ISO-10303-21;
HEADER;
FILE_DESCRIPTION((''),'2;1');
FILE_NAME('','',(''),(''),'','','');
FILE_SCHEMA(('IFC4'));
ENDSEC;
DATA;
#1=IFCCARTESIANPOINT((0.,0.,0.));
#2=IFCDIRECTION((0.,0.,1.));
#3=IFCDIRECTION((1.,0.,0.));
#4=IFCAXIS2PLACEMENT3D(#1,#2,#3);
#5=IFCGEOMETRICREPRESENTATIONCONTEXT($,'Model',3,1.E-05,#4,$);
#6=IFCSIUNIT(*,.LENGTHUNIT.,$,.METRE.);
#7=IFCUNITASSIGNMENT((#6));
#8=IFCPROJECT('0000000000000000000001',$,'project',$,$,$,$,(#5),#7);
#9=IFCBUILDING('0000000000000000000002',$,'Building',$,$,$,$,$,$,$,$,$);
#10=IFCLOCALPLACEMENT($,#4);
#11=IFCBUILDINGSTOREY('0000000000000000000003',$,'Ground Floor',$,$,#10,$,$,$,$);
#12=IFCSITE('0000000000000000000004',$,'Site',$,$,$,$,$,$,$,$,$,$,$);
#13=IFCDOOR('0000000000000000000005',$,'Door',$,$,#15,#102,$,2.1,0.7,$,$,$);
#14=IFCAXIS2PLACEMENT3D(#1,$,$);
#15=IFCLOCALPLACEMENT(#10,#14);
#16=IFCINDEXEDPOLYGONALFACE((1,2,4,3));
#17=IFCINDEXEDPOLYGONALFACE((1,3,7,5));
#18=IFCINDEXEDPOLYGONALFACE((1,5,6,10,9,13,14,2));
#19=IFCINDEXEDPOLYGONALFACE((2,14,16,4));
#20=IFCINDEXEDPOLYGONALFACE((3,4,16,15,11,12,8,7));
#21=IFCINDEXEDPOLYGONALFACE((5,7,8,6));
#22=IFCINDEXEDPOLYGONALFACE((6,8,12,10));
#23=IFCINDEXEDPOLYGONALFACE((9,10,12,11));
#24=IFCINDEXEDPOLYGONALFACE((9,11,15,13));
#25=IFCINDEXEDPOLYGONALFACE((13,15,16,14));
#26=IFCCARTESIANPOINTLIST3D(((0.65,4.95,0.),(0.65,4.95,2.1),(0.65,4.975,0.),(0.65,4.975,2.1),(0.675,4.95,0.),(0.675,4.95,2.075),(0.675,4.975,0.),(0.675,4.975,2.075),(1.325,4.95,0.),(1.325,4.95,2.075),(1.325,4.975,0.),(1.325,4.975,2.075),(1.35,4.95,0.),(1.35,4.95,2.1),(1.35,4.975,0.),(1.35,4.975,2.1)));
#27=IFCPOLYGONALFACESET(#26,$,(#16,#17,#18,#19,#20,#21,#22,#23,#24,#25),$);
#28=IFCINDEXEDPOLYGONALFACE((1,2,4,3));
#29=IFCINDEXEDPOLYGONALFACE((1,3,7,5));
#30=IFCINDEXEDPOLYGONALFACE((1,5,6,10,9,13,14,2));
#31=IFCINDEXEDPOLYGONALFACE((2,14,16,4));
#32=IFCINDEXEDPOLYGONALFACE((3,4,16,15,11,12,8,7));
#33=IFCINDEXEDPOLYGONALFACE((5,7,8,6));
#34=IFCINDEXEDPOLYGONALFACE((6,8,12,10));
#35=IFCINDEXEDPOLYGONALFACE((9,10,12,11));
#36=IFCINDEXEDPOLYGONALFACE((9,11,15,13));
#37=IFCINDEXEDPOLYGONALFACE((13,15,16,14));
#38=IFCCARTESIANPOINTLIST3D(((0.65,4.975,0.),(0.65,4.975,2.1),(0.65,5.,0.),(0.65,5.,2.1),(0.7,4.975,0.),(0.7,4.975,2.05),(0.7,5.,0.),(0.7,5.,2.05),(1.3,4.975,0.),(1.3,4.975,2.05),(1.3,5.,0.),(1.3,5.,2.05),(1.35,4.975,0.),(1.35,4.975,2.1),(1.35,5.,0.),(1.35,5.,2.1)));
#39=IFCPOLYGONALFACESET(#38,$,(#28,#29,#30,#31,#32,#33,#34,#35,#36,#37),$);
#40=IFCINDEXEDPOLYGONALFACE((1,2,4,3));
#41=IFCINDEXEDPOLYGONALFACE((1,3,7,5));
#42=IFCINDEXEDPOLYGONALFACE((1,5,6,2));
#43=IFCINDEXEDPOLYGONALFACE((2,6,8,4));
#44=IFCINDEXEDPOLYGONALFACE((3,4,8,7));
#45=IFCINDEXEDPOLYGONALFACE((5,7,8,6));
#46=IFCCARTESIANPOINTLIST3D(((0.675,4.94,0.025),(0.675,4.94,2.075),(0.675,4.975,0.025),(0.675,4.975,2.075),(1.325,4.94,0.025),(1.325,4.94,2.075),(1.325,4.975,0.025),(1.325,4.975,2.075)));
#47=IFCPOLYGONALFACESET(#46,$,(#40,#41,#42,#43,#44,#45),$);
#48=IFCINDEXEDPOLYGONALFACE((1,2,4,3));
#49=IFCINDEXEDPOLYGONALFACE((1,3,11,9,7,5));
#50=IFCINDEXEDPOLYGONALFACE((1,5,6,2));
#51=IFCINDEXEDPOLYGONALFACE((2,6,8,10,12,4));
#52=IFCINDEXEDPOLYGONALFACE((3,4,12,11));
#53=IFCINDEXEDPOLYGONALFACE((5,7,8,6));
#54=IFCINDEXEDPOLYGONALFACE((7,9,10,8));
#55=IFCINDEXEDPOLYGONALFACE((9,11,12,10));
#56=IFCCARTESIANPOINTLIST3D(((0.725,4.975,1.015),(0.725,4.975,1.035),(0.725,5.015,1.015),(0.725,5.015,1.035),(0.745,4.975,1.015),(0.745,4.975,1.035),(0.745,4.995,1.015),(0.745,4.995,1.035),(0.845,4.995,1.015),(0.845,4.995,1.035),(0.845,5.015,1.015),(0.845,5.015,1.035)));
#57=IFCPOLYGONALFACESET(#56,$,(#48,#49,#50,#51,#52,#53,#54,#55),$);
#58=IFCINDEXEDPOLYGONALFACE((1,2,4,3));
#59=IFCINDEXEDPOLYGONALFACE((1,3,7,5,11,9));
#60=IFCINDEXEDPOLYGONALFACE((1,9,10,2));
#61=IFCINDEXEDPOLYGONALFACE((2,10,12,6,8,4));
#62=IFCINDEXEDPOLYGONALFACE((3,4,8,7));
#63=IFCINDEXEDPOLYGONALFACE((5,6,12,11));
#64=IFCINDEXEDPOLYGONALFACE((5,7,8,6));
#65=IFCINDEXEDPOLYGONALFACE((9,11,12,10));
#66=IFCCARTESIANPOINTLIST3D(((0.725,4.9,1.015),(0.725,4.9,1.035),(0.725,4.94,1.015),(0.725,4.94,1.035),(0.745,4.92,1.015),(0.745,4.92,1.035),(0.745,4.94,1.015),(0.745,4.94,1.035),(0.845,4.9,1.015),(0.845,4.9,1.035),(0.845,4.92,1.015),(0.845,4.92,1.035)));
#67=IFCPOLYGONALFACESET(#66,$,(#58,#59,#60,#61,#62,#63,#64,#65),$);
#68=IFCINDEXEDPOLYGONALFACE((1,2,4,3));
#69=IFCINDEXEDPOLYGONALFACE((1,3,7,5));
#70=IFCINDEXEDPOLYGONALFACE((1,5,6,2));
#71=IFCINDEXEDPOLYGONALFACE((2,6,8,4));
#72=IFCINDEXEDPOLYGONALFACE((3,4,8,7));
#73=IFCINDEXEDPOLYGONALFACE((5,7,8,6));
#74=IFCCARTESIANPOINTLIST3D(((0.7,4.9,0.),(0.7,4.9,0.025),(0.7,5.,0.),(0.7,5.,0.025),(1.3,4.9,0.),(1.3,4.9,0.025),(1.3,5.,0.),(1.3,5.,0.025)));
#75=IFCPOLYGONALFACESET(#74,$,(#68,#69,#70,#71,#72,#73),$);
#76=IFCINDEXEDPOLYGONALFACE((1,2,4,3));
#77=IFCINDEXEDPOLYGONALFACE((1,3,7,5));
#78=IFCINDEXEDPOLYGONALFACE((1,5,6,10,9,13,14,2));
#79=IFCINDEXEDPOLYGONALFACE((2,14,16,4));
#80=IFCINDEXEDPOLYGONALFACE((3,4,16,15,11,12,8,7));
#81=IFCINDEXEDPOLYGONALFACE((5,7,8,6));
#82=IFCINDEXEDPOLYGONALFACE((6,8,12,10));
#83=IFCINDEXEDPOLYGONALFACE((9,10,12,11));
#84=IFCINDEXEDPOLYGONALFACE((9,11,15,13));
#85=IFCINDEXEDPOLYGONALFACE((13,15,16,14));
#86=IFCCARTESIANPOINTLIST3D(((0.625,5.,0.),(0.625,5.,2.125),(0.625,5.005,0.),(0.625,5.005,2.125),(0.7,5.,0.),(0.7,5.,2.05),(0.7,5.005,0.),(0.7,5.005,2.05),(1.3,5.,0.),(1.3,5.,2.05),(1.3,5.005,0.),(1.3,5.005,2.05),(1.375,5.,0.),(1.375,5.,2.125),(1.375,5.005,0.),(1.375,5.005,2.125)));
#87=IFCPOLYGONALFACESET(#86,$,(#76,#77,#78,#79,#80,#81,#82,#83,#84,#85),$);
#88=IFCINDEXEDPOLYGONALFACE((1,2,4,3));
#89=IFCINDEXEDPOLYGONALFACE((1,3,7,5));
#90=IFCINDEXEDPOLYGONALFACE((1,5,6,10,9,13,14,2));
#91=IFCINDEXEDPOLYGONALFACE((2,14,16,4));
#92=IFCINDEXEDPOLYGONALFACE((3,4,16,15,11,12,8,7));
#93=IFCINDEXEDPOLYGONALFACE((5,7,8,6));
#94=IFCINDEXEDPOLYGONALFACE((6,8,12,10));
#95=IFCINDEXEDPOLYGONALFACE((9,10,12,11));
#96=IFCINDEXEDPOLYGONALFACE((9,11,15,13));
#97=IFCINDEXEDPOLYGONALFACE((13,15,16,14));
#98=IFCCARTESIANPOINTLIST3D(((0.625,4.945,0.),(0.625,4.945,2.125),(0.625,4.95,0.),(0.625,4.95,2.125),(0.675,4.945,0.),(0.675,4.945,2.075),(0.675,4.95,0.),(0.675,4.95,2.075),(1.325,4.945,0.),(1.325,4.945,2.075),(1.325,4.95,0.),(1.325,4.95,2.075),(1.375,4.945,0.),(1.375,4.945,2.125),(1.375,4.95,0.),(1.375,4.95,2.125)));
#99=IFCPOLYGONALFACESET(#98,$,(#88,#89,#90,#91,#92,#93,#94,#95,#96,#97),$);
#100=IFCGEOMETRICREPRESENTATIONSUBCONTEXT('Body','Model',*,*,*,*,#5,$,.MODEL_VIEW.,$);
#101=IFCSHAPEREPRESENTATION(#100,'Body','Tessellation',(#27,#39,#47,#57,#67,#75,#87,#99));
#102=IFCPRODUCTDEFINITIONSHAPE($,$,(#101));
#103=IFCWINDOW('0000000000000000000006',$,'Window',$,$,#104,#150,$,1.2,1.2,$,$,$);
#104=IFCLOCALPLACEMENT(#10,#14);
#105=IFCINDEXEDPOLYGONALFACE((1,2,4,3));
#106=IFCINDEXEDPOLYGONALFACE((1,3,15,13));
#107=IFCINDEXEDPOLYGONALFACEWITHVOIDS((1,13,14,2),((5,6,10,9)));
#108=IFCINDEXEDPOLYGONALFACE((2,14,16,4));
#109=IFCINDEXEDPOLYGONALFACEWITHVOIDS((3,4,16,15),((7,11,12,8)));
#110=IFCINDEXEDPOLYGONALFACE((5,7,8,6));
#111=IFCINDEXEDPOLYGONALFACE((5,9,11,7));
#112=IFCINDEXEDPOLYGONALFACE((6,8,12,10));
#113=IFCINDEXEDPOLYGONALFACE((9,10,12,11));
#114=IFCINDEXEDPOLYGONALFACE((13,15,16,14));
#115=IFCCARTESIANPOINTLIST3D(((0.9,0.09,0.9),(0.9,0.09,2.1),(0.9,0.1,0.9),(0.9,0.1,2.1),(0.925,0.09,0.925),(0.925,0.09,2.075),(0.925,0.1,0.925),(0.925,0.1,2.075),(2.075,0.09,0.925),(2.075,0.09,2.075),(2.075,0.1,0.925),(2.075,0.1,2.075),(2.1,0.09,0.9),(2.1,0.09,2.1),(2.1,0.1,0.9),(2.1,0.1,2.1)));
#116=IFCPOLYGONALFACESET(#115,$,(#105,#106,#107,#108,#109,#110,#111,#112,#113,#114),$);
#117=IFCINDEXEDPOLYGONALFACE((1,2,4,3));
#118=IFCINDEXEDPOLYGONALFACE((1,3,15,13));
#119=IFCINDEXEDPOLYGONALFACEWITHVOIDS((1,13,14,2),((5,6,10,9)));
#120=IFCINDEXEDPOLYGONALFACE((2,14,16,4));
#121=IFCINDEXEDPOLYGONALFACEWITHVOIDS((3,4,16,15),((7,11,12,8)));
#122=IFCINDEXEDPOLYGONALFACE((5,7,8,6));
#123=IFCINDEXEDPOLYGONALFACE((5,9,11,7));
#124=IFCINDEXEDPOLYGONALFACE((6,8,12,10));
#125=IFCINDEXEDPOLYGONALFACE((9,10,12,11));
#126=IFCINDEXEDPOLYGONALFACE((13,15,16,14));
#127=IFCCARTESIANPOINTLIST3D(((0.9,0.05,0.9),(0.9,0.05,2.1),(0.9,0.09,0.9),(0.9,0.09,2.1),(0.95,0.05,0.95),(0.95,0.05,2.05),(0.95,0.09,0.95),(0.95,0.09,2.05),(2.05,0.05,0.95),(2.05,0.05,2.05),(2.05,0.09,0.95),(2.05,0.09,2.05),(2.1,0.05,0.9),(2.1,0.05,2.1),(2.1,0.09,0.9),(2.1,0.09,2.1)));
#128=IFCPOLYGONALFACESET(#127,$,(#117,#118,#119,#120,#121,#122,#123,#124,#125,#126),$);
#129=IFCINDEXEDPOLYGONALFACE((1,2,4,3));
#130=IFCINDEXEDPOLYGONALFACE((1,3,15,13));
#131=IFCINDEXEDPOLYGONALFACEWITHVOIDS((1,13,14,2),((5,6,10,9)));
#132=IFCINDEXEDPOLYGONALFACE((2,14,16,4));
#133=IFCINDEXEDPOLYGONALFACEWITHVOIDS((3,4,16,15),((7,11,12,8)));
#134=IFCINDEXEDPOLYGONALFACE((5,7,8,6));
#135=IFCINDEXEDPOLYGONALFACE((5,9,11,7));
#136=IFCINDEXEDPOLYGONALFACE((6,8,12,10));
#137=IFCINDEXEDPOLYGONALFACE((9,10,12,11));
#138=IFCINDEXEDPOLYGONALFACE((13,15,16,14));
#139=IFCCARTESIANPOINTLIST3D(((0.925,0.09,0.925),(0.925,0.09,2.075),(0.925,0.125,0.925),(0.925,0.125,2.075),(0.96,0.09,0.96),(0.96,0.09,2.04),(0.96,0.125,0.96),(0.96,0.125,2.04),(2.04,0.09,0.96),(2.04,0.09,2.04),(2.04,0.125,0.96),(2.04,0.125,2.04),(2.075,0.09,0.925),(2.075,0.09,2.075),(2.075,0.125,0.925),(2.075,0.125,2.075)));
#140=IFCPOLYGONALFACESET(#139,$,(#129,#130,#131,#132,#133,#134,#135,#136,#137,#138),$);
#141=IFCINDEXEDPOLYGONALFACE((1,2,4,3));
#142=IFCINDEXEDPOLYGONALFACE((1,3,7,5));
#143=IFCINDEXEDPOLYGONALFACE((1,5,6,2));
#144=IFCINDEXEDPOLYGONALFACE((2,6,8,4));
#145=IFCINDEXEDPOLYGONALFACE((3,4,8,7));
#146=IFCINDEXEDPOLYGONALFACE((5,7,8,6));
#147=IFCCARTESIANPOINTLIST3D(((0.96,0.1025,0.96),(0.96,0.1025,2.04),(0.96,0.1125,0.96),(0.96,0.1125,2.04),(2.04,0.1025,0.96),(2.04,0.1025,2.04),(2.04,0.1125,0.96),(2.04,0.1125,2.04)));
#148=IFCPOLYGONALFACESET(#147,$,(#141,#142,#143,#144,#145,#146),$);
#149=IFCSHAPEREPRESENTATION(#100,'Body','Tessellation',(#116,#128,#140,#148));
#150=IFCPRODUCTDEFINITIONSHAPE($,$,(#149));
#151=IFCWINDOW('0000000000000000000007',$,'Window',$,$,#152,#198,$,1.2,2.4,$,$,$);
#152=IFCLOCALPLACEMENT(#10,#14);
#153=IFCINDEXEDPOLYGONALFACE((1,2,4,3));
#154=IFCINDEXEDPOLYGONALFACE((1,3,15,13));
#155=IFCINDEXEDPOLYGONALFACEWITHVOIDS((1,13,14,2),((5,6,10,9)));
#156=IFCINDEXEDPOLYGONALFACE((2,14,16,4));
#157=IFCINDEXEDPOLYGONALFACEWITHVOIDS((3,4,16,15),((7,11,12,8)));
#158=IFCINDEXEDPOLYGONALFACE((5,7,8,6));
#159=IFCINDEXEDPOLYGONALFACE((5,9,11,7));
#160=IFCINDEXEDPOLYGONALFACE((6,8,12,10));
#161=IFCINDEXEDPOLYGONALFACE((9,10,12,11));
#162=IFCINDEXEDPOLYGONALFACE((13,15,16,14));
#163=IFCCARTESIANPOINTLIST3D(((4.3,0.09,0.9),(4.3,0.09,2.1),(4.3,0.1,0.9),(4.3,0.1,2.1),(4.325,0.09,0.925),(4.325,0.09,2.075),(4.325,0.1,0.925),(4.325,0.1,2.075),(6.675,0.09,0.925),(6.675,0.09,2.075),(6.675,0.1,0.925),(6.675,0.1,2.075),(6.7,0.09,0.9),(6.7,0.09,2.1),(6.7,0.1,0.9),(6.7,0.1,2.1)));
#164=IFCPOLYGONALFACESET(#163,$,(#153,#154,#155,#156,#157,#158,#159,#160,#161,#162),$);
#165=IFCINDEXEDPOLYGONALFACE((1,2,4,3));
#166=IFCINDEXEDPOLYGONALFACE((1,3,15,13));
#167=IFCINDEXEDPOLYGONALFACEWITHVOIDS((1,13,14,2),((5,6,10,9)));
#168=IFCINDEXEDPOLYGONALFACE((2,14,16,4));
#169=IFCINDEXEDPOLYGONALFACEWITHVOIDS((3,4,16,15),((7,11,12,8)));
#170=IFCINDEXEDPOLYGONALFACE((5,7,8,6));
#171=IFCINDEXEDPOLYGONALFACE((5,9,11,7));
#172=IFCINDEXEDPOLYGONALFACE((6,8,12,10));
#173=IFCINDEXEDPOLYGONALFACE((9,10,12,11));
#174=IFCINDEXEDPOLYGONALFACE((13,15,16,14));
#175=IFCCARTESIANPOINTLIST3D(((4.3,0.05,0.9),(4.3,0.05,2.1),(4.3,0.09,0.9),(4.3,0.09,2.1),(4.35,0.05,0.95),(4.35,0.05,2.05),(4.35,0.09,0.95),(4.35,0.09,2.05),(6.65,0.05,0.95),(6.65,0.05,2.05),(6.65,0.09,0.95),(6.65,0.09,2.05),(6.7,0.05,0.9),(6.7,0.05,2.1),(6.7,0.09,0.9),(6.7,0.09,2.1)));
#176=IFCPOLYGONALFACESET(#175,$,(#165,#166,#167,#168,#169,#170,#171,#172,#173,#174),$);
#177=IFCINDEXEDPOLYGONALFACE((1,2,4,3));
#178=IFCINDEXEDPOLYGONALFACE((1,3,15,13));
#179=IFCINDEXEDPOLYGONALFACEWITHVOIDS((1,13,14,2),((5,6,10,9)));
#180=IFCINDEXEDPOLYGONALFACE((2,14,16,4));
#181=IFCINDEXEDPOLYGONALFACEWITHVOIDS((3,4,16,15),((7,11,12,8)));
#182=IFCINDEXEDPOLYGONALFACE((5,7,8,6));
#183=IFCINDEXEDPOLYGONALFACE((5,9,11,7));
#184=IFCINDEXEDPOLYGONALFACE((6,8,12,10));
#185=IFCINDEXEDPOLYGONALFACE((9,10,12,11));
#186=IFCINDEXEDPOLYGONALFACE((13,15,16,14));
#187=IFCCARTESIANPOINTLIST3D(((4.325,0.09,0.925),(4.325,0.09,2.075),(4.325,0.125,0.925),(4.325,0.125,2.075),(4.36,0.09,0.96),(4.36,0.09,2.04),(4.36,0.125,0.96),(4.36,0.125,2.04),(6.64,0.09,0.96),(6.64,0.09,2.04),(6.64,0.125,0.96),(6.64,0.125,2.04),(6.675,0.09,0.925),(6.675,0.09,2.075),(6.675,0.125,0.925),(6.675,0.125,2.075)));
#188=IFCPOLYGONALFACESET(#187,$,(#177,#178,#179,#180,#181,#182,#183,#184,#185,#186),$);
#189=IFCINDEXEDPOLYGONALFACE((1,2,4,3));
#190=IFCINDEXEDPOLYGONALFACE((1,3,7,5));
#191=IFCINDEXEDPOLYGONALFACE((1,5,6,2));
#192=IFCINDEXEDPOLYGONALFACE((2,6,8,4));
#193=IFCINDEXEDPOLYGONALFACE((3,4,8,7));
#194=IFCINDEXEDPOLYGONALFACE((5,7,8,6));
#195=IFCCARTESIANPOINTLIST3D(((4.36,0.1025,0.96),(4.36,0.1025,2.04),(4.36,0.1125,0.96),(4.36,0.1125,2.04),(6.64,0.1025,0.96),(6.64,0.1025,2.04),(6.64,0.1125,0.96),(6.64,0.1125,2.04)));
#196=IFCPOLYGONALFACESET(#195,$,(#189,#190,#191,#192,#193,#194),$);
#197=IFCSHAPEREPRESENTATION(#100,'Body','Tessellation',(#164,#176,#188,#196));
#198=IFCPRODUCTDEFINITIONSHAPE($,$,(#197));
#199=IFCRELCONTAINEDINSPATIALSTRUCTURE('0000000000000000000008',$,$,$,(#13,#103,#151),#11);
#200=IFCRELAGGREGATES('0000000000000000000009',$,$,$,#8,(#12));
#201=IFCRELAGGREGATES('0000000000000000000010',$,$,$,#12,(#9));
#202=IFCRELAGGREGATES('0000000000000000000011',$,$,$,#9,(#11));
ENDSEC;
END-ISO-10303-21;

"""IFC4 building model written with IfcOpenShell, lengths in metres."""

from ifc_helpers import new_model, si_unit, frame, origin_with_axes, place, context, subcontext, project, spatial, line, indexed_curve, outline, extrude, element, save


model = new_model("IFC4")

# Units and contexts
model_context = context("Model", 3, precision=1e-05, world=origin_with_axes())
body_context = subcontext(model_context, "Body", "Model", "MODEL_VIEW")
ifc_project = project(units=[si_unit("LENGTHUNIT", "METRE")], contexts=[model_context])

# Site, building, storey
site = spatial("IfcSite", under=ifc_project, Name="Site")
building = spatial("IfcBuilding", under=site, Name="Building")
storey_placement = place(None, origin_with_axes())
storey = spatial("IfcBuildingStorey", under=building, at=storey_placement, Name="Ground Floor")

# Door
door_1_placement = place(storey_placement, frame((1.35, 5.0, 0.0), z_axis=(0.0, 0.0, 1.0), x_axis=(-1.0, 0.0, 0.0)))
element("IfcDoor", 1, at=door_1_placement, inside=storey, Name="Door", OverallHeight=2.1, OverallWidth=0.7, context=body_context, shape_type="SweptSolid", body=[
    extrude(outline(indexed_curve([(0.0, 0.0), (0.0, 2.1), (0.7, 2.1), (0.7, 0.0), (0.675, 0.0), (0.675, 2.075), (0.025, 2.075), (0.025, 0.0)], segments=[line(1, 2, 3, 4, 5, 6, 7, 8, 1)])), frame((0.0, 0.025, 0.0), z_axis=(0.0, -1.0, 0.0), x_axis=(1.0, 0.0, 0.0)), (0.0, 0.0, -1.0), 0.025),
    extrude(outline(indexed_curve([(0.0, 0.0), (0.0, 2.1), (0.7, 2.1), (0.7, 0.0), (0.65, 0.0), (0.65, 2.05), (0.05, 2.05), (0.05, 0.0)], segments=[line(1, 2, 3, 4, 5, 6, 7, 8, 1)])), frame((0.0, 0.0, 0.0), z_axis=(0.0, -1.0, 0.0), x_axis=(1.0, 0.0, 0.0)), (0.0, 0.0, -1.0), 0.025),
    extrude(outline(indexed_curve([(0.0, 0.0), (0.65, 0.0), (0.65, 0.035), (0.0, 0.035)], segments=[line(1, 2, 3, 4, 1)])), frame((0.025, 0.025, 0.025), z_axis=(0.0, 0.0, 1.0), x_axis=(1.0, 0.0, 0.0)), (0.0, 0.0, 1.0), 2.05),
    extrude(outline(indexed_curve([(0.0, 0.0), (0.0, -0.04), (-0.12, -0.04), (-0.12, -0.02), (-0.02, -0.02), (-0.02, 0.0)], segments=[line(1, 2, 3, 4, 5, 6, 1)])), frame((0.625, 0.025, 1.015), z_axis=(0.0, 0.0, 1.0), x_axis=(1.0, 0.0, 0.0)), (0.0, 0.0, 1.0), 0.02),
    extrude(outline(indexed_curve([(0.0, 0.0), (0.0, 0.04), (-0.12, 0.04), (-0.12, 0.02), (-0.02, 0.02), (-0.02, 0.0)], segments=[line(1, 2, 3, 4, 5, 6, 1)])), frame((0.625, 0.06, 1.015), z_axis=(0.0, 0.0, 1.0), x_axis=(1.0, 0.0, 0.0)), (0.0, 0.0, 1.0), 0.02),
    extrude(outline(indexed_curve([(0.0, 0.0), (0.6, 0.0), (0.6, 0.1), (0.0, 0.1)], segments=[line(1, 2, 3, 4, 1)])), frame((0.05, 0.0, 0.0), z_axis=(0.0, 0.0, 1.0), x_axis=(1.0, 0.0, 0.0)), (0.0, 0.0, 1.0), 0.025),
    extrude(outline(indexed_curve([(0.0, 0.0), (0.0, 2.125), (0.75, 2.125), (0.75, 0.0), (0.675, 0.0), (0.675, 2.05), (0.075, 2.05), (0.075, 0.0)], segments=[line(1, 2, 3, 4, 5, 6, 7, 8, 1)])), frame((-0.025, -0.005, 0.0), z_axis=(0.0, -1.0, 0.0), x_axis=(1.0, 0.0, 0.0)), (0.0, 0.0, -1.0), 0.005),
    extrude(outline(indexed_curve([(0.0, 0.0), (0.0, 2.125), (0.75, 2.125), (0.75, 0.0), (0.7, 0.0), (0.7, 2.075), (0.05, 2.075), (0.05, 0.0)], segments=[line(1, 2, 3, 4, 5, 6, 7, 8, 1)])), frame((-0.025, 0.05, 0.0), z_axis=(0.0, -1.0, 0.0), x_axis=(1.0, 0.0, 0.0)), (0.0, 0.0, -1.0), 0.005),
])

# Windows
window_1_placement = place(storey_placement, frame((0.9, 0.0, 0.9), z_axis=(0.0, 0.0, 1.0), x_axis=(1.0, 0.0, 0.0)))
element("IfcWindow", 2, at=window_1_placement, inside=storey, Name="Window", OverallHeight=1.2, OverallWidth=1.2, context=body_context, shape_type="SweptSolid", body=[
    extrude(outline(indexed_curve([(0.0, 0.0), (1.2, 0.0), (1.2, 1.2), (0.0, 1.2)], segments=[line(1, 2, 3, 4, 1)]), holes=[indexed_curve([(0.025, 0.025), (1.175, 0.025), (1.175, 1.175), (0.025, 1.175)], segments=[line(1, 2, 3, 4, 1)])]), frame((0.0, 0.09, 0.0), z_axis=(0.0, -1.0, 0.0), x_axis=(1.0, 0.0, 0.0)), (0.0, 0.0, -1.0), 0.01),
    extrude(outline(indexed_curve([(0.0, 0.0), (1.2, 0.0), (1.2, 1.2), (0.0, 1.2)], segments=[line(1, 2, 3, 4, 1)]), holes=[indexed_curve([(0.05, 0.05), (1.15, 0.05), (1.15, 1.15), (0.05, 1.15)], segments=[line(1, 2, 3, 4, 1)])]), frame((0.0, 0.05, 0.0), z_axis=(0.0, -1.0, 0.0), x_axis=(1.0, 0.0, 0.0)), (0.0, 0.0, -1.0), 0.04),
    extrude(outline(indexed_curve([(0.0, 0.0), (1.15, 0.0), (1.15, 1.15), (0.0, 1.15)], segments=[line(1, 2, 3, 4, 1)]), holes=[indexed_curve([(0.035, 0.035), (1.115, 0.035), (1.115, 1.115), (0.035, 1.115)], segments=[line(1, 2, 3, 4, 1)])]), frame((0.025, 0.09, 0.025), z_axis=(0.0, -1.0, 0.0), x_axis=(1.0, 0.0, 0.0)), (0.0, 0.0, -1.0), 0.035),
    extrude(outline(indexed_curve([(0.035, 0.035), (1.115, 0.035), (1.115, 1.115), (0.035, 1.115)], segments=[line(1, 2, 3, 4, 1)])), frame((0.025, 0.1025, 0.025), z_axis=(0.0, -1.0, 0.0), x_axis=(1.0, 0.0, 0.0)), (0.0, 0.0, -1.0), 0.01),
])
window_2_placement = place(storey_placement, frame((4.3, 0.0, 0.9), z_axis=(0.0, 0.0, 1.0), x_axis=(1.0, 0.0, 0.0)))
element("IfcWindow", 3, at=window_2_placement, inside=storey, Name="Window", OverallHeight=1.2, OverallWidth=2.4, context=body_context, shape_type="SweptSolid", body=[
    extrude(outline(indexed_curve([(0.0, 0.0), (2.4, 0.0), (2.4, 1.2), (0.0, 1.2)], segments=[line(1, 2, 3, 4, 1)]), holes=[indexed_curve([(0.025, 0.025), (2.375, 0.025), (2.375, 1.175), (0.025, 1.175)], segments=[line(1, 2, 3, 4, 1)])]), frame((0.0, 0.09, 0.0), z_axis=(0.0, -1.0, 0.0), x_axis=(1.0, 0.0, 0.0)), (0.0, 0.0, -1.0), 0.01),
    extrude(outline(indexed_curve([(0.0, 0.0), (2.4, 0.0), (2.4, 1.2), (0.0, 1.2)], segments=[line(1, 2, 3, 4, 1)]), holes=[indexed_curve([(0.05, 0.05), (2.35, 0.05), (2.35, 1.15), (0.05, 1.15)], segments=[line(1, 2, 3, 4, 1)])]), frame((0.0, 0.05, 0.0), z_axis=(0.0, -1.0, 0.0), x_axis=(1.0, 0.0, 0.0)), (0.0, 0.0, -1.0), 0.04),
    extrude(outline(indexed_curve([(0.0, 0.0), (2.35, 0.0), (2.35, 1.15), (0.0, 1.15)], segments=[line(1, 2, 3, 4, 1)]), holes=[indexed_curve([(0.035, 0.035), (2.315, 0.035), (2.315, 1.115), (0.035, 1.115)], segments=[line(1, 2, 3, 4, 1)])]), frame((0.025, 0.09, 0.025), z_axis=(0.0, -1.0, 0.0), x_axis=(1.0, 0.0, 0.0)), (0.0, 0.0, -1.0), 0.035),
    extrude(outline(indexed_curve([(0.035, 0.035), (2.315, 0.035), (2.315, 1.115), (0.035, 1.115)], segments=[line(1, 2, 3, 4, 1)])), frame((0.025, 0.1025, 0.025), z_axis=(0.0, -1.0, 0.0), x_axis=(1.0, 0.0, 0.0)), (0.0, 0.0, -1.0), 0.01),
])

save(model, "model.ifc")
